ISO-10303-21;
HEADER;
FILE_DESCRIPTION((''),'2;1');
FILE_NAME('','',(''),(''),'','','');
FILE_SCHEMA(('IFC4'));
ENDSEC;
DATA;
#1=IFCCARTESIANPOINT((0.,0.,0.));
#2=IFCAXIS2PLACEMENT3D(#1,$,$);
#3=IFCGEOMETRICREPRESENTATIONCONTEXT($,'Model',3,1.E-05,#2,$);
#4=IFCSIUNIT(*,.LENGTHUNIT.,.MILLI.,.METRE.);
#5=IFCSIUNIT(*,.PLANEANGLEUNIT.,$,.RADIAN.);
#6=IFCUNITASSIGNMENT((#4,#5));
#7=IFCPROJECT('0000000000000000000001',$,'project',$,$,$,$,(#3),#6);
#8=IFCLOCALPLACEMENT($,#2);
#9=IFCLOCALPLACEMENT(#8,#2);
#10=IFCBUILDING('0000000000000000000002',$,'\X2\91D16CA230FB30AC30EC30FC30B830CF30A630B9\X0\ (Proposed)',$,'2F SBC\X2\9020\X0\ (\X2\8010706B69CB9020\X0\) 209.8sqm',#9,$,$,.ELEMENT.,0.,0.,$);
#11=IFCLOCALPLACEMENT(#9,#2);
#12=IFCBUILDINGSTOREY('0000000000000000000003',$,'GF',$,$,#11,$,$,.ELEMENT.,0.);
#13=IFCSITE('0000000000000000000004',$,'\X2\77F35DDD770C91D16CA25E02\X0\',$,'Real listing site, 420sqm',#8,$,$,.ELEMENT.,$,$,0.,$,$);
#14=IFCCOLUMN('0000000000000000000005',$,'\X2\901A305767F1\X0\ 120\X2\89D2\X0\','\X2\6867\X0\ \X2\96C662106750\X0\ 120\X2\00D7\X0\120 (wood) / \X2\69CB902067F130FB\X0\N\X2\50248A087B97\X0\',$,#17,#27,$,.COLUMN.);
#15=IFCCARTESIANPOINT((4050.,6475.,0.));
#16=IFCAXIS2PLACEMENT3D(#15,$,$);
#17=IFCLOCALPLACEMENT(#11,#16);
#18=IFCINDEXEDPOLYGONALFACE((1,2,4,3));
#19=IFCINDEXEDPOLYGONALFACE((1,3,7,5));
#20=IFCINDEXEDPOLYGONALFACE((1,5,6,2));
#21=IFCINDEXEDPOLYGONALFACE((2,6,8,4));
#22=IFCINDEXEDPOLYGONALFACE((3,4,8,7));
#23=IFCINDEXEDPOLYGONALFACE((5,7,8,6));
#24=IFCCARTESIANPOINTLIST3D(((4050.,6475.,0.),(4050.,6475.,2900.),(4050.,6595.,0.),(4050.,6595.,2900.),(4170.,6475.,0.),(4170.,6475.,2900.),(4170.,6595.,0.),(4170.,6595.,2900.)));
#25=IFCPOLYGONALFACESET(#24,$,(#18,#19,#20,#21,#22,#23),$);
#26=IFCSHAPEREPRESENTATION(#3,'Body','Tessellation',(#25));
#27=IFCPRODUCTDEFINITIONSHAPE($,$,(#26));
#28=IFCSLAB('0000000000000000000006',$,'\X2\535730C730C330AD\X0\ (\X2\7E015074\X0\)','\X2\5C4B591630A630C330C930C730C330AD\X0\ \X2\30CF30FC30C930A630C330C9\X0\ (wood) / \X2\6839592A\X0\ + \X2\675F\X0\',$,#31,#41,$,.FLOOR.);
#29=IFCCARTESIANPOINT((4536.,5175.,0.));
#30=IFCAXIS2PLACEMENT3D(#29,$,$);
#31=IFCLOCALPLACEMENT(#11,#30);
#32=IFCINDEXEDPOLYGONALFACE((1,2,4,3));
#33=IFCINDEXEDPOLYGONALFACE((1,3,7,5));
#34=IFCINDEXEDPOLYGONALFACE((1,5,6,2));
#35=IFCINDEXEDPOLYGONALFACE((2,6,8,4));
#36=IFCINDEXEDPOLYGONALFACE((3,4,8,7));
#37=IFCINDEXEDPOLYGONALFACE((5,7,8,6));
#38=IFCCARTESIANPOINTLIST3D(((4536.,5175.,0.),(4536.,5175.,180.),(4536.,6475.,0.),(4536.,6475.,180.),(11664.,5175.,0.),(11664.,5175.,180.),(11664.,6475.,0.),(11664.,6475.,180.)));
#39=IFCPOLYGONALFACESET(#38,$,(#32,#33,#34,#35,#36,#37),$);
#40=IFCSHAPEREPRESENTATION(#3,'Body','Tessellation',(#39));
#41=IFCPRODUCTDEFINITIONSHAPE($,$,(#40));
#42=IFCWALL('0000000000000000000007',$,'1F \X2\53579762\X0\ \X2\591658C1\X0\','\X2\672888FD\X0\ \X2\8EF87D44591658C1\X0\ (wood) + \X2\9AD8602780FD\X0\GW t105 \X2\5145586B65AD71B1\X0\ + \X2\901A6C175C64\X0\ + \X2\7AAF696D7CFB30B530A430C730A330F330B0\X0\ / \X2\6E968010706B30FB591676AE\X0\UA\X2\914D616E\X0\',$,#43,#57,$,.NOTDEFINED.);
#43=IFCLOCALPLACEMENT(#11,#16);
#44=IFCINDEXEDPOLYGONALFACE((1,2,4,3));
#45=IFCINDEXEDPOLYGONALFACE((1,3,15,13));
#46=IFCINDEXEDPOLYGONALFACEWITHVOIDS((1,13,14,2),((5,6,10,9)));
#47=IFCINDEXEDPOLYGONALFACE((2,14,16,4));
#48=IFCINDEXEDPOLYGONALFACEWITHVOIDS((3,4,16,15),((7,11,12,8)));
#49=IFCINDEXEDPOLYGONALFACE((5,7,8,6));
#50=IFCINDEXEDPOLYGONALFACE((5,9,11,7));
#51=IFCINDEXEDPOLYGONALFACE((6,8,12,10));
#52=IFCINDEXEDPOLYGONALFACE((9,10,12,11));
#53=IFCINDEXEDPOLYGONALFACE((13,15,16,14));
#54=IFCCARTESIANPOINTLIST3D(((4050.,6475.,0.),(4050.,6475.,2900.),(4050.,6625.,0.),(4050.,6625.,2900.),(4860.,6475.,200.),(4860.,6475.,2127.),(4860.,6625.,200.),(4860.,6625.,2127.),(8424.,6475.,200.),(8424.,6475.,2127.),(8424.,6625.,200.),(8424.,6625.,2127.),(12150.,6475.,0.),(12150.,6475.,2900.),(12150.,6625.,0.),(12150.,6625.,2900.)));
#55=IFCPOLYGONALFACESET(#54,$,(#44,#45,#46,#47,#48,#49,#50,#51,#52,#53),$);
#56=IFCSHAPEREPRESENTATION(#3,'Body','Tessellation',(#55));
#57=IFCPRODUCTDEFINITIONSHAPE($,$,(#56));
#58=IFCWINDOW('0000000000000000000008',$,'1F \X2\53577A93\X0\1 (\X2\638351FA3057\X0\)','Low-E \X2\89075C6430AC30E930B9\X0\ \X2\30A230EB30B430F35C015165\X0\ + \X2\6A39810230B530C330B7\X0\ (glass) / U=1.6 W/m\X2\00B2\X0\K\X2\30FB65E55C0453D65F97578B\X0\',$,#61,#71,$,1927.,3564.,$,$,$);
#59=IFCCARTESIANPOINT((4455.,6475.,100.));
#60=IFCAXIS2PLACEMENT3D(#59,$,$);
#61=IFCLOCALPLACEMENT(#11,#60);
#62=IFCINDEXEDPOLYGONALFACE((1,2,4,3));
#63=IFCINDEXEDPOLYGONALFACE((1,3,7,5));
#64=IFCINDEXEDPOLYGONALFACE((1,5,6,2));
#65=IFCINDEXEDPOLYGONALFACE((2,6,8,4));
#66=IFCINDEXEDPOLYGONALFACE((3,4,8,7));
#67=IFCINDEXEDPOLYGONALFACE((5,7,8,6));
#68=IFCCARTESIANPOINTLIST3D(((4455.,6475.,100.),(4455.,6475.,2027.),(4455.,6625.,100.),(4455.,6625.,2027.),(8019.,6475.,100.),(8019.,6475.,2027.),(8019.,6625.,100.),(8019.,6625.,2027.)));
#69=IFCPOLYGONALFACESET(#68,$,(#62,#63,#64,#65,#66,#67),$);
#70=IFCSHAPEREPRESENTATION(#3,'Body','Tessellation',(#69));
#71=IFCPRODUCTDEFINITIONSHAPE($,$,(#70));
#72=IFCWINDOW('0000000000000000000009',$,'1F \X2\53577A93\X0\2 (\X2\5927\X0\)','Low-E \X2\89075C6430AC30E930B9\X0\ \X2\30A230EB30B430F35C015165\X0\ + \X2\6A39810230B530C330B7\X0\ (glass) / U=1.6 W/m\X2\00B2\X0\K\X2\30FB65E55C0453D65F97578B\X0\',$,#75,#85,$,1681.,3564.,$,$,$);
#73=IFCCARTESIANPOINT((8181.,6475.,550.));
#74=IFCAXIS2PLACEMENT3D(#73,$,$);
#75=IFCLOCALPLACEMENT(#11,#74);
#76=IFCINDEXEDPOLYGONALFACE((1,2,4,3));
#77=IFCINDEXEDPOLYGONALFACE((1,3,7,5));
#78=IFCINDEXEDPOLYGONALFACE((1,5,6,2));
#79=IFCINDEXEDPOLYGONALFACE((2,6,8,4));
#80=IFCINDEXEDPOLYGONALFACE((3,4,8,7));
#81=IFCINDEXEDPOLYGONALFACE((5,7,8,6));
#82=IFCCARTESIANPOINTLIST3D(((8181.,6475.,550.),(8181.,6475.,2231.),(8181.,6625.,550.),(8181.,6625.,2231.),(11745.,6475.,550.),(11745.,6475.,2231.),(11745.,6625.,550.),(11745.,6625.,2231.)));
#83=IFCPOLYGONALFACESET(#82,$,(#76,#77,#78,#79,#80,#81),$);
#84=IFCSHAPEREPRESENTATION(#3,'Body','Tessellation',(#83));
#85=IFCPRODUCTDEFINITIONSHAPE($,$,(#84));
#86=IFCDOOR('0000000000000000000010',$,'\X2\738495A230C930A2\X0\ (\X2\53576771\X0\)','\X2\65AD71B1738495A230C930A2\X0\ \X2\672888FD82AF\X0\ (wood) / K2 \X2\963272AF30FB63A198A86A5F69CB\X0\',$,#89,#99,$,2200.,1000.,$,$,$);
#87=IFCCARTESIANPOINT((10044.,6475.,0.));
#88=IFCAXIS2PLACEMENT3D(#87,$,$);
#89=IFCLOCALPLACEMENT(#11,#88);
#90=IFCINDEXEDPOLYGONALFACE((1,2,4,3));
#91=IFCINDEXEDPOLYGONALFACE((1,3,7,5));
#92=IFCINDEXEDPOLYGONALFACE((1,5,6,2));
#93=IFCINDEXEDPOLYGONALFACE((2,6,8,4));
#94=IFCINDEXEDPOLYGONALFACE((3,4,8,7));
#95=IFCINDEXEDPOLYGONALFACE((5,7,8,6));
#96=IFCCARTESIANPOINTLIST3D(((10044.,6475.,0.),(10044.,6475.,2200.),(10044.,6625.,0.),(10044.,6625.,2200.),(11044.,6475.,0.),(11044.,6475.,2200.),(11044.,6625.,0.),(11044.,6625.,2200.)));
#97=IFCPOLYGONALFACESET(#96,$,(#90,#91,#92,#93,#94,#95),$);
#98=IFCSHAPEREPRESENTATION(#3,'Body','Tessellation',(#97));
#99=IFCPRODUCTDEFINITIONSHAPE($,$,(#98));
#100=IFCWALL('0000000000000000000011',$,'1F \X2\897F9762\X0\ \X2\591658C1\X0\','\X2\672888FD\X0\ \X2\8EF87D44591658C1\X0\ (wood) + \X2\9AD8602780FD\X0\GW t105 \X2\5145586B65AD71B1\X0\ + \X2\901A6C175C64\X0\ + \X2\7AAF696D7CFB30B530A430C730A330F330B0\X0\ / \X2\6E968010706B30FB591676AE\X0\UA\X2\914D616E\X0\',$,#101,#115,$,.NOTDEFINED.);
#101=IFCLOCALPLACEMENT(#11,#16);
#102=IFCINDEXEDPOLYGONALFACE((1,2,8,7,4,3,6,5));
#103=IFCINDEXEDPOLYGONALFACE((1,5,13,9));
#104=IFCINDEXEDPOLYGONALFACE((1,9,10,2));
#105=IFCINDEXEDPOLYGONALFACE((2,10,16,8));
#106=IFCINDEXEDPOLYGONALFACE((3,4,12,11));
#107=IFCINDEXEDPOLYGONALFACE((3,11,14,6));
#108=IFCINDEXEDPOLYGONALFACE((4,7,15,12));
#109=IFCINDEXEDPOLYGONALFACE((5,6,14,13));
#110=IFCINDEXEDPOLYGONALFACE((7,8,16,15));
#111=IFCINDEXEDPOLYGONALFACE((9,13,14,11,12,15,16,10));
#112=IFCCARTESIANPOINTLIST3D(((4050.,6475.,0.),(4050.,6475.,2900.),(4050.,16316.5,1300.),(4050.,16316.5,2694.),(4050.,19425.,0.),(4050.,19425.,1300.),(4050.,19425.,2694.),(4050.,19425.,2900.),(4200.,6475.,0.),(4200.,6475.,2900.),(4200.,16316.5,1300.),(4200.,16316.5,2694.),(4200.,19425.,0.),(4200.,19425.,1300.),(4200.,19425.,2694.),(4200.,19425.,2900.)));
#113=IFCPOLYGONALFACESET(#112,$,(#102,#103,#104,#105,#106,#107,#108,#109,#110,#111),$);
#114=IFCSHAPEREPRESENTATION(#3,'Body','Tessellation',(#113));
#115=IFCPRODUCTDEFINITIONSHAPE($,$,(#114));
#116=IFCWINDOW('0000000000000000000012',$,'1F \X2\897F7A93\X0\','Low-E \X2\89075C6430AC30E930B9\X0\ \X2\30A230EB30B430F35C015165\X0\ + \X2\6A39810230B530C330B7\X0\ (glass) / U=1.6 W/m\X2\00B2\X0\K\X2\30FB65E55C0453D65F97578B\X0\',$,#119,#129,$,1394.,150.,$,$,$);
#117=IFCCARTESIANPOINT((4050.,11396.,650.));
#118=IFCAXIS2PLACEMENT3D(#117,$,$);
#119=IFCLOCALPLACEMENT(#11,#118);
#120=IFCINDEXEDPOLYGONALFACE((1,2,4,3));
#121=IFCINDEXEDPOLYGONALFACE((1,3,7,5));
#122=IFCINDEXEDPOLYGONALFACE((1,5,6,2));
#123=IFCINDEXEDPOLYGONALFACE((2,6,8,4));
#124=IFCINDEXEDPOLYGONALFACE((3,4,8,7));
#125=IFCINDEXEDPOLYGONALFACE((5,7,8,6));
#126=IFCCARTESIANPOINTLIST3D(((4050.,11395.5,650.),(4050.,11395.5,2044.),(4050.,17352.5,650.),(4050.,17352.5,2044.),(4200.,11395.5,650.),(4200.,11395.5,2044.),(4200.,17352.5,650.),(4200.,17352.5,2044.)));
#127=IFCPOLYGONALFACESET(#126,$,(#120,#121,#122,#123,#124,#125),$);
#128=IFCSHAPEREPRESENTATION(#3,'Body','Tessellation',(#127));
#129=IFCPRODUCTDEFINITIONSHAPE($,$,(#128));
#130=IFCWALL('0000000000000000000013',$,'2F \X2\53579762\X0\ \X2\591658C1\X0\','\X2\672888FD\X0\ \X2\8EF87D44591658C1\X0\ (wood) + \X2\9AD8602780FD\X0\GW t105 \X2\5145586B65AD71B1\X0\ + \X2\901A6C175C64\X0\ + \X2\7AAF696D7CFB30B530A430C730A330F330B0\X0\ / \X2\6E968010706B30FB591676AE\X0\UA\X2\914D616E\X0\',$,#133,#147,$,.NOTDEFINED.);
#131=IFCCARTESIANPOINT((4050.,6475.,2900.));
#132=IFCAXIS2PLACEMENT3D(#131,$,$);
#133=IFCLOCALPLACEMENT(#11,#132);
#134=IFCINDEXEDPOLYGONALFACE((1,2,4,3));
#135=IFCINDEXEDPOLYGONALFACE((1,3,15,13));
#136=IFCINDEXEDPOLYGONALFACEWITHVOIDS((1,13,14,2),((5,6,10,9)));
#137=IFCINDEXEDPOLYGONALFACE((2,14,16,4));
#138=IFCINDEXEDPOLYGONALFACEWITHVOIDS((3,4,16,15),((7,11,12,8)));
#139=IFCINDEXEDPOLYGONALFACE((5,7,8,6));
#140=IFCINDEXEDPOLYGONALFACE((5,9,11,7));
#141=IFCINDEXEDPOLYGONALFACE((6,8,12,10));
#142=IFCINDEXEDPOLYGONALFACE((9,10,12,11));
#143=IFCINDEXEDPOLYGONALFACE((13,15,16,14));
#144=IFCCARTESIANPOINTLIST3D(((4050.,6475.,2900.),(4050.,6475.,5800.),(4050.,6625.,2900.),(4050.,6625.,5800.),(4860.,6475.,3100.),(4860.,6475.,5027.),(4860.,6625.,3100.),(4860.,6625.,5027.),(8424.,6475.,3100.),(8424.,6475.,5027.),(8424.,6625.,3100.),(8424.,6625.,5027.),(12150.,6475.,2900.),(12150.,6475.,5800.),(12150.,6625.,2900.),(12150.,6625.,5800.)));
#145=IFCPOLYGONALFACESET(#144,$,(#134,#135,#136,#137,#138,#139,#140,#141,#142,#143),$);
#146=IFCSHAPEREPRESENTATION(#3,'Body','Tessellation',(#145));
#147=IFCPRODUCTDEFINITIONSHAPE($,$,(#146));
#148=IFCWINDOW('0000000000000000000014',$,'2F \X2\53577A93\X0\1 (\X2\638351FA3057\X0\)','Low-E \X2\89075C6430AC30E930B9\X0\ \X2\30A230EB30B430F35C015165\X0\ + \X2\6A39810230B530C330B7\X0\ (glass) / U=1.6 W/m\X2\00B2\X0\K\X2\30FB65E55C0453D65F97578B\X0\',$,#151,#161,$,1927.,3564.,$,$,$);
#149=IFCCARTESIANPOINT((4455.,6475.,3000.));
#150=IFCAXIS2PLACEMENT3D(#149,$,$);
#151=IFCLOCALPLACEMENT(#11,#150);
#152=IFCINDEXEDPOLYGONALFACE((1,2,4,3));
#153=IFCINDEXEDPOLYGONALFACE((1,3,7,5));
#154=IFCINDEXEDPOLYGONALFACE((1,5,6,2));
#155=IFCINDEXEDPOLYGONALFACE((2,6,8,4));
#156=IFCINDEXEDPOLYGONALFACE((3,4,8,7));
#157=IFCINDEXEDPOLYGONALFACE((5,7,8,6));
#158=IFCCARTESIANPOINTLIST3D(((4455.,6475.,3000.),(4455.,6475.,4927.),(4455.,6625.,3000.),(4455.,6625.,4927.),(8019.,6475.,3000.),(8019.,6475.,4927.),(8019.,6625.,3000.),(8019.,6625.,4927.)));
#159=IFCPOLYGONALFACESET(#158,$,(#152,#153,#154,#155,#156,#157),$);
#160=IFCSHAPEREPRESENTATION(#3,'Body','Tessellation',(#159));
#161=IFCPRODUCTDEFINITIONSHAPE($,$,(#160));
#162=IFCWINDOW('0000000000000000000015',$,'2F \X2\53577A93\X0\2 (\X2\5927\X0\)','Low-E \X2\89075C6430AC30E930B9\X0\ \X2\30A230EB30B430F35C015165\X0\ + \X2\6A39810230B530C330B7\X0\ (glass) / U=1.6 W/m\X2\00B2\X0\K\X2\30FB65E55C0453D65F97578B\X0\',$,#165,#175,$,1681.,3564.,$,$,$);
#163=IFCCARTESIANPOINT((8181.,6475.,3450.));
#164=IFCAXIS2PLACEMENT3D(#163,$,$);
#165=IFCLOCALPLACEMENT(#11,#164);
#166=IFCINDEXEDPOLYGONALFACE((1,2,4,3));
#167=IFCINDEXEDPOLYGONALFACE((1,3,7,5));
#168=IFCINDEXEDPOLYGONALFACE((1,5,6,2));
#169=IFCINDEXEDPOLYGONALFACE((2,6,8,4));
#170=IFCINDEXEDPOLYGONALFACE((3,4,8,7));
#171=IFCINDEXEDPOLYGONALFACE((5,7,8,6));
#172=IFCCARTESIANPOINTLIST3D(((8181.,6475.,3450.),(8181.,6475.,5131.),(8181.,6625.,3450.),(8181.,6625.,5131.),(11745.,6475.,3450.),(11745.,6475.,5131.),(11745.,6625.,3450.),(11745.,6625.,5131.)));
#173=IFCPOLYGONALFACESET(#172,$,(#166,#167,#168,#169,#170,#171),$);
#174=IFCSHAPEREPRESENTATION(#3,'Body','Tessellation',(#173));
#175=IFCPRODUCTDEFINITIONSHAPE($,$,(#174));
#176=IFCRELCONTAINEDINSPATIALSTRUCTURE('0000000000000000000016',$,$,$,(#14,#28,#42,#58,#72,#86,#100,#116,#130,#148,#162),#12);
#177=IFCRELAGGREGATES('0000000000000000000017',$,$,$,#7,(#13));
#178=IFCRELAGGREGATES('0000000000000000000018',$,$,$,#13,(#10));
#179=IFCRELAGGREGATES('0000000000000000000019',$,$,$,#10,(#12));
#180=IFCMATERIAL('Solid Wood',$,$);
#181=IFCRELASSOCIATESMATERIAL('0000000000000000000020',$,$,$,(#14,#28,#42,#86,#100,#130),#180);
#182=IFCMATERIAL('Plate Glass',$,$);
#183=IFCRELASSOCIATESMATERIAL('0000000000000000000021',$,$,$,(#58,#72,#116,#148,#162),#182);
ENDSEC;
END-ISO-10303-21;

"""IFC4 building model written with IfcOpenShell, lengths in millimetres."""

from ifc_helpers import new_model, si_unit, frame, frame_2d, origin, place, context, project, spatial, rectangle, extrude, material, element, fill, save


model = new_model("IFC4")

# Units and contexts
model_context = context("Model", 3, precision=1e-05, world=origin())
ifc_project = project(units=[si_unit("LENGTHUNIT", "METRE", prefix="MILLI"), si_unit("PLANEANGLEUNIT", "RADIAN")], contexts=[model_context])

# Site, building, storey
site_placement = place(None, origin())
site = spatial("IfcSite", under=ifc_project, at=site_placement, Name="石川県金沢市", ObjectType="Real listing site, 420sqm", CompositionType="ELEMENT", RefElevation=0.0)
building_placement = place(site_placement, origin())
building = spatial("IfcBuilding", under=site, at=building_placement, Name="金沢・ガレージハウス (Proposed)", ObjectType="2F SBC造 (耐火構造) 209.8sqm", CompositionType="ELEMENT", ElevationOfRefHeight=0.0, ElevationOfTerrain=0.0)
storey_placement = place(building_placement, origin())
storey = spatial("IfcBuildingStorey", under=building, at=storey_placement, Name="GF", CompositionType="ELEMENT", Elevation=0.0)

# Column
ifc_material_1 = material(Name="Solid Wood")
column_placement = place(storey_placement, frame((4050.0, 6475.0, 0.0)))
element("IfcColumn", 1, at=column_placement, inside=storey, material=ifc_material_1, Name="通し柱 120角", Description="桧 集成材 120×120 (wood) / 構造柱・N値計算", PredefinedType="COLUMN", context=model_context, shape_type="SweptSolid", body=[
    extrude(rectangle(XDim=120.0, YDim=120.0, at=frame_2d((60.0, 60.0))), frame((4050.0, 6475.0, 0.0)), (0.0, 0.0, 1.0), 2900.0),
])

# Slab
slab_1_placement = place(storey_placement, frame((4536.0, 5175.0, 0.0)))
element("IfcSlab", 2, at=slab_1_placement, inside=storey, material=ifc_material_1, Name="南デッキ (縁側)", Description="屋外ウッドデッキ ハードウッド (wood) / 根太 + 束", PredefinedType="FLOOR", context=model_context, shape_type="SweptSolid", body=[
    extrude(rectangle(XDim=7128.0, YDim=1300.0, at=frame_2d((3564.0, 650.0))), frame((4536.0, 5175.0, 0.0)), (0.0, 0.0, 1.0), 180.0),
])

# Wall, openings, windows, door
wall_1_placement = place(storey_placement, frame((4050.0, 6475.0, 0.0)))
wall_1 = element("IfcWall", 3, at=wall_1_placement, inside=storey, material=ifc_material_1, Name="1F 南面 外壁", Description="木製 軸組外壁 (wood) + 高性能GW t105 充填断熱 + 通気層 + 窯業系サイディング / 準耐火・外皮UA配慮", PredefinedType="NOTDEFINED", context=model_context, shape_type="SweptSolid", body=[
    extrude(rectangle(XDim=8100.0, YDim=150.0, at=frame_2d((4050.0, 75.0))), frame((4050.0, 6475.0, 0.0)), (0.0, 0.0, 1.0), 2900.0),
])
opening_1_placement = place(storey_placement, frame((4455.0, 6475.0, 100.0)))
opening_1 = element("IfcOpeningElement", 4, at=opening_1_placement, cuts=wall_1, PredefinedType="NOTDEFINED", context=model_context, shape_type="SweptSolid", body=[
    extrude(rectangle(XDim=3564.0, YDim=150.0, at=frame_2d((1782.0, 75.0))), frame((4455.0, 6475.0, 100.0)), (0.0, 0.0, 1.0), 1927.0),
])
opening_2_placement = place(storey_placement, frame((8181.0, 6475.0, 550.0)))
opening_2 = element("IfcOpeningElement", 5, at=opening_2_placement, cuts=wall_1, PredefinedType="NOTDEFINED", context=model_context, shape_type="SweptSolid", body=[
    extrude(rectangle(XDim=3564.0, YDim=150.0, at=frame_2d((1782.0, 75.0))), frame((8181.0, 6475.0, 550.0)), (0.0, 0.0, 1.0), 1681.0),
])
opening_3_placement = place(storey_placement, frame((10044.0, 6475.0, 0.0)))
opening_3 = element("IfcOpeningElement", 6, at=opening_3_placement, cuts=wall_1, PredefinedType="NOTDEFINED", context=model_context, shape_type="SweptSolid", body=[
    extrude(rectangle(XDim=1000.0, YDim=150.0, at=frame_2d((500.0, 75.0))), frame((10044.0, 6475.0, 0.0)), (0.0, 0.0, 1.0), 2200.0),
])
ifc_material_2 = material(Name="Plate Glass")
window_1_placement = place(storey_placement, frame((4455.0, 6475.0, 100.0)))
window_1 = element("IfcWindow", 7, at=window_1_placement, inside=storey, material=ifc_material_2, Name="1F 南窓1 (掃出し)", Description="Low-E 複層ガラス アルゴン封入 + 樹脂サッシ (glass) / U=1.6 W/m²K・日射取得型", OverallHeight=1927.0, OverallWidth=3564.0, context=model_context, shape_type="SweptSolid", body=[
    extrude(rectangle(XDim=3564.0, YDim=150.0, at=frame_2d((1782.0, 75.0))), frame((4455.0, 6475.0, 100.0)), (0.0, 0.0, 1.0), 1927.0),
])
fill(opening_1, window_1)
window_2_placement = place(storey_placement, frame((8181.0, 6475.0, 550.0)))
window_2 = element("IfcWindow", 8, at=window_2_placement, inside=storey, material=ifc_material_2, Name="1F 南窓2 (大)", Description="Low-E 複層ガラス アルゴン封入 + 樹脂サッシ (glass) / U=1.6 W/m²K・日射取得型", OverallHeight=1681.0, OverallWidth=3564.0, context=model_context, shape_type="SweptSolid", body=[
    extrude(rectangle(XDim=3564.0, YDim=150.0, at=frame_2d((1782.0, 75.0))), frame((8181.0, 6475.0, 550.0)), (0.0, 0.0, 1.0), 1681.0),
])
fill(opening_2, window_2)
door_placement = place(storey_placement, frame((10044.0, 6475.0, 0.0)))
door = element("IfcDoor", 9, at=door_placement, inside=storey, material=ifc_material_1, Name="玄関ドア (南東)", Description="断熱玄関ドア 木製芯 (wood) / K2 防犯・採風機構", OverallHeight=2200.0, OverallWidth=1000.0, context=model_context, shape_type="SweptSolid", body=[
    extrude(rectangle(XDim=1000.0, YDim=150.0, at=frame_2d((500.0, 75.0))), frame((10044.0, 6475.0, 0.0)), (0.0, 0.0, 1.0), 2200.0),
])
fill(opening_3, door)

# Wall, opening, window
wall_2_placement = place(storey_placement, frame((4050.0, 6475.0, 0.0)))
wall_2 = element("IfcWall", 10, at=wall_2_placement, inside=storey, material=ifc_material_1, Name="1F 西面 外壁", Description="木製 軸組外壁 (wood) + 高性能GW t105 充填断熱 + 通気層 + 窯業系サイディング / 準耐火・外皮UA配慮", PredefinedType="NOTDEFINED", context=model_context, shape_type="SweptSolid", body=[
    extrude(rectangle(XDim=150.0, YDim=12950.0, at=frame_2d((75.0, 6475.0))), frame((4050.0, 6475.0, 0.0)), (0.0, 0.0, 1.0), 2900.0),
])
opening_4_placement = place(storey_placement, frame((4050.0, 11396.0, 650.0)))
opening_4 = element("IfcOpeningElement", 11, at=opening_4_placement, cuts=wall_2, PredefinedType="NOTDEFINED", context=model_context, shape_type="SweptSolid", body=[
    extrude(rectangle(XDim=150.0, YDim=5957.0, at=frame_2d((75.0, 2978.0))), frame((4050.0, 11396.0, 650.0)), (0.0, 0.0, 1.0), 1394.0),
])
window_3_placement = place(storey_placement, frame((4050.0, 11396.0, 650.0)))
window_3 = element("IfcWindow", 12, at=window_3_placement, inside=storey, material=ifc_material_2, Name="1F 西窓", Description="Low-E 複層ガラス アルゴン封入 + 樹脂サッシ (glass) / U=1.6 W/m²K・日射取得型", OverallHeight=1394.0, OverallWidth=150.0, context=model_context, shape_type="SweptSolid", body=[
    extrude(rectangle(XDim=150.0, YDim=5957.0, at=frame_2d((75.0, 2978.0))), frame((4050.0, 11396.0, 650.0)), (0.0, 0.0, 1.0), 1394.0),
])
fill(opening_4, window_3)

# Wall, openings, windows
wall_3_placement = place(storey_placement, frame((4050.0, 6475.0, 2900.0)))
wall_3 = element("IfcWall", 13, at=wall_3_placement, inside=storey, material=ifc_material_1, Name="2F 南面 外壁", Description="木製 軸組外壁 (wood) + 高性能GW t105 充填断熱 + 通気層 + 窯業系サイディング / 準耐火・外皮UA配慮", PredefinedType="NOTDEFINED", context=model_context, shape_type="SweptSolid", body=[
    extrude(rectangle(XDim=8100.0, YDim=150.0, at=frame_2d((4050.0, 75.0))), frame((4050.0, 6475.0, 2900.0)), (0.0, 0.0, 1.0), 2900.0),
])
opening_5_placement = place(storey_placement, frame((4455.0, 6475.0, 3000.0)))
opening_5 = element("IfcOpeningElement", 14, at=opening_5_placement, cuts=wall_3, PredefinedType="NOTDEFINED", context=model_context, shape_type="SweptSolid", body=[
    extrude(rectangle(XDim=3564.0, YDim=150.0, at=frame_2d((1782.0, 75.0))), frame((4455.0, 6475.0, 3000.0)), (0.0, 0.0, 1.0), 1927.0),
])
opening_6_placement = place(storey_placement, frame((8181.0, 6475.0, 3450.0)))
opening_6 = element("IfcOpeningElement", 15, at=opening_6_placement, cuts=wall_3, PredefinedType="NOTDEFINED", context=model_context, shape_type="SweptSolid", body=[
    extrude(rectangle(XDim=3564.0, YDim=150.0, at=frame_2d((1782.0, 75.0))), frame((8181.0, 6475.0, 3450.0)), (0.0, 0.0, 1.0), 1681.0),
])
window_4_placement = place(storey_placement, frame((4455.0, 6475.0, 3000.0)))
window_4 = element("IfcWindow", 16, at=window_4_placement, inside=storey, material=ifc_material_2, Name="2F 南窓1 (掃出し)", Description="Low-E 複層ガラス アルゴン封入 + 樹脂サッシ (glass) / U=1.6 W/m²K・日射取得型", OverallHeight=1927.0, OverallWidth=3564.0, context=model_context, shape_type="SweptSolid", body=[
    extrude(rectangle(XDim=3564.0, YDim=150.0, at=frame_2d((1782.0, 75.0))), frame((4455.0, 6475.0, 3000.0)), (0.0, 0.0, 1.0), 1927.0),
])
fill(opening_5, window_4)
window_5_placement = place(storey_placement, frame((8181.0, 6475.0, 3450.0)))
window_5 = element("IfcWindow", 17, at=window_5_placement, inside=storey, material=ifc_material_2, Name="2F 南窓2 (大)", Description="Low-E 複層ガラス アルゴン封入 + 樹脂サッシ (glass) / U=1.6 W/m²K・日射取得型", OverallHeight=1681.0, OverallWidth=3564.0, context=model_context, shape_type="SweptSolid", body=[
    extrude(rectangle(XDim=3564.0, YDim=150.0, at=frame_2d((1782.0, 75.0))), frame((8181.0, 6475.0, 3450.0)), (0.0, 0.0, 1.0), 1681.0),
])
fill(opening_6, window_5)

save(model, "model.ifc")
